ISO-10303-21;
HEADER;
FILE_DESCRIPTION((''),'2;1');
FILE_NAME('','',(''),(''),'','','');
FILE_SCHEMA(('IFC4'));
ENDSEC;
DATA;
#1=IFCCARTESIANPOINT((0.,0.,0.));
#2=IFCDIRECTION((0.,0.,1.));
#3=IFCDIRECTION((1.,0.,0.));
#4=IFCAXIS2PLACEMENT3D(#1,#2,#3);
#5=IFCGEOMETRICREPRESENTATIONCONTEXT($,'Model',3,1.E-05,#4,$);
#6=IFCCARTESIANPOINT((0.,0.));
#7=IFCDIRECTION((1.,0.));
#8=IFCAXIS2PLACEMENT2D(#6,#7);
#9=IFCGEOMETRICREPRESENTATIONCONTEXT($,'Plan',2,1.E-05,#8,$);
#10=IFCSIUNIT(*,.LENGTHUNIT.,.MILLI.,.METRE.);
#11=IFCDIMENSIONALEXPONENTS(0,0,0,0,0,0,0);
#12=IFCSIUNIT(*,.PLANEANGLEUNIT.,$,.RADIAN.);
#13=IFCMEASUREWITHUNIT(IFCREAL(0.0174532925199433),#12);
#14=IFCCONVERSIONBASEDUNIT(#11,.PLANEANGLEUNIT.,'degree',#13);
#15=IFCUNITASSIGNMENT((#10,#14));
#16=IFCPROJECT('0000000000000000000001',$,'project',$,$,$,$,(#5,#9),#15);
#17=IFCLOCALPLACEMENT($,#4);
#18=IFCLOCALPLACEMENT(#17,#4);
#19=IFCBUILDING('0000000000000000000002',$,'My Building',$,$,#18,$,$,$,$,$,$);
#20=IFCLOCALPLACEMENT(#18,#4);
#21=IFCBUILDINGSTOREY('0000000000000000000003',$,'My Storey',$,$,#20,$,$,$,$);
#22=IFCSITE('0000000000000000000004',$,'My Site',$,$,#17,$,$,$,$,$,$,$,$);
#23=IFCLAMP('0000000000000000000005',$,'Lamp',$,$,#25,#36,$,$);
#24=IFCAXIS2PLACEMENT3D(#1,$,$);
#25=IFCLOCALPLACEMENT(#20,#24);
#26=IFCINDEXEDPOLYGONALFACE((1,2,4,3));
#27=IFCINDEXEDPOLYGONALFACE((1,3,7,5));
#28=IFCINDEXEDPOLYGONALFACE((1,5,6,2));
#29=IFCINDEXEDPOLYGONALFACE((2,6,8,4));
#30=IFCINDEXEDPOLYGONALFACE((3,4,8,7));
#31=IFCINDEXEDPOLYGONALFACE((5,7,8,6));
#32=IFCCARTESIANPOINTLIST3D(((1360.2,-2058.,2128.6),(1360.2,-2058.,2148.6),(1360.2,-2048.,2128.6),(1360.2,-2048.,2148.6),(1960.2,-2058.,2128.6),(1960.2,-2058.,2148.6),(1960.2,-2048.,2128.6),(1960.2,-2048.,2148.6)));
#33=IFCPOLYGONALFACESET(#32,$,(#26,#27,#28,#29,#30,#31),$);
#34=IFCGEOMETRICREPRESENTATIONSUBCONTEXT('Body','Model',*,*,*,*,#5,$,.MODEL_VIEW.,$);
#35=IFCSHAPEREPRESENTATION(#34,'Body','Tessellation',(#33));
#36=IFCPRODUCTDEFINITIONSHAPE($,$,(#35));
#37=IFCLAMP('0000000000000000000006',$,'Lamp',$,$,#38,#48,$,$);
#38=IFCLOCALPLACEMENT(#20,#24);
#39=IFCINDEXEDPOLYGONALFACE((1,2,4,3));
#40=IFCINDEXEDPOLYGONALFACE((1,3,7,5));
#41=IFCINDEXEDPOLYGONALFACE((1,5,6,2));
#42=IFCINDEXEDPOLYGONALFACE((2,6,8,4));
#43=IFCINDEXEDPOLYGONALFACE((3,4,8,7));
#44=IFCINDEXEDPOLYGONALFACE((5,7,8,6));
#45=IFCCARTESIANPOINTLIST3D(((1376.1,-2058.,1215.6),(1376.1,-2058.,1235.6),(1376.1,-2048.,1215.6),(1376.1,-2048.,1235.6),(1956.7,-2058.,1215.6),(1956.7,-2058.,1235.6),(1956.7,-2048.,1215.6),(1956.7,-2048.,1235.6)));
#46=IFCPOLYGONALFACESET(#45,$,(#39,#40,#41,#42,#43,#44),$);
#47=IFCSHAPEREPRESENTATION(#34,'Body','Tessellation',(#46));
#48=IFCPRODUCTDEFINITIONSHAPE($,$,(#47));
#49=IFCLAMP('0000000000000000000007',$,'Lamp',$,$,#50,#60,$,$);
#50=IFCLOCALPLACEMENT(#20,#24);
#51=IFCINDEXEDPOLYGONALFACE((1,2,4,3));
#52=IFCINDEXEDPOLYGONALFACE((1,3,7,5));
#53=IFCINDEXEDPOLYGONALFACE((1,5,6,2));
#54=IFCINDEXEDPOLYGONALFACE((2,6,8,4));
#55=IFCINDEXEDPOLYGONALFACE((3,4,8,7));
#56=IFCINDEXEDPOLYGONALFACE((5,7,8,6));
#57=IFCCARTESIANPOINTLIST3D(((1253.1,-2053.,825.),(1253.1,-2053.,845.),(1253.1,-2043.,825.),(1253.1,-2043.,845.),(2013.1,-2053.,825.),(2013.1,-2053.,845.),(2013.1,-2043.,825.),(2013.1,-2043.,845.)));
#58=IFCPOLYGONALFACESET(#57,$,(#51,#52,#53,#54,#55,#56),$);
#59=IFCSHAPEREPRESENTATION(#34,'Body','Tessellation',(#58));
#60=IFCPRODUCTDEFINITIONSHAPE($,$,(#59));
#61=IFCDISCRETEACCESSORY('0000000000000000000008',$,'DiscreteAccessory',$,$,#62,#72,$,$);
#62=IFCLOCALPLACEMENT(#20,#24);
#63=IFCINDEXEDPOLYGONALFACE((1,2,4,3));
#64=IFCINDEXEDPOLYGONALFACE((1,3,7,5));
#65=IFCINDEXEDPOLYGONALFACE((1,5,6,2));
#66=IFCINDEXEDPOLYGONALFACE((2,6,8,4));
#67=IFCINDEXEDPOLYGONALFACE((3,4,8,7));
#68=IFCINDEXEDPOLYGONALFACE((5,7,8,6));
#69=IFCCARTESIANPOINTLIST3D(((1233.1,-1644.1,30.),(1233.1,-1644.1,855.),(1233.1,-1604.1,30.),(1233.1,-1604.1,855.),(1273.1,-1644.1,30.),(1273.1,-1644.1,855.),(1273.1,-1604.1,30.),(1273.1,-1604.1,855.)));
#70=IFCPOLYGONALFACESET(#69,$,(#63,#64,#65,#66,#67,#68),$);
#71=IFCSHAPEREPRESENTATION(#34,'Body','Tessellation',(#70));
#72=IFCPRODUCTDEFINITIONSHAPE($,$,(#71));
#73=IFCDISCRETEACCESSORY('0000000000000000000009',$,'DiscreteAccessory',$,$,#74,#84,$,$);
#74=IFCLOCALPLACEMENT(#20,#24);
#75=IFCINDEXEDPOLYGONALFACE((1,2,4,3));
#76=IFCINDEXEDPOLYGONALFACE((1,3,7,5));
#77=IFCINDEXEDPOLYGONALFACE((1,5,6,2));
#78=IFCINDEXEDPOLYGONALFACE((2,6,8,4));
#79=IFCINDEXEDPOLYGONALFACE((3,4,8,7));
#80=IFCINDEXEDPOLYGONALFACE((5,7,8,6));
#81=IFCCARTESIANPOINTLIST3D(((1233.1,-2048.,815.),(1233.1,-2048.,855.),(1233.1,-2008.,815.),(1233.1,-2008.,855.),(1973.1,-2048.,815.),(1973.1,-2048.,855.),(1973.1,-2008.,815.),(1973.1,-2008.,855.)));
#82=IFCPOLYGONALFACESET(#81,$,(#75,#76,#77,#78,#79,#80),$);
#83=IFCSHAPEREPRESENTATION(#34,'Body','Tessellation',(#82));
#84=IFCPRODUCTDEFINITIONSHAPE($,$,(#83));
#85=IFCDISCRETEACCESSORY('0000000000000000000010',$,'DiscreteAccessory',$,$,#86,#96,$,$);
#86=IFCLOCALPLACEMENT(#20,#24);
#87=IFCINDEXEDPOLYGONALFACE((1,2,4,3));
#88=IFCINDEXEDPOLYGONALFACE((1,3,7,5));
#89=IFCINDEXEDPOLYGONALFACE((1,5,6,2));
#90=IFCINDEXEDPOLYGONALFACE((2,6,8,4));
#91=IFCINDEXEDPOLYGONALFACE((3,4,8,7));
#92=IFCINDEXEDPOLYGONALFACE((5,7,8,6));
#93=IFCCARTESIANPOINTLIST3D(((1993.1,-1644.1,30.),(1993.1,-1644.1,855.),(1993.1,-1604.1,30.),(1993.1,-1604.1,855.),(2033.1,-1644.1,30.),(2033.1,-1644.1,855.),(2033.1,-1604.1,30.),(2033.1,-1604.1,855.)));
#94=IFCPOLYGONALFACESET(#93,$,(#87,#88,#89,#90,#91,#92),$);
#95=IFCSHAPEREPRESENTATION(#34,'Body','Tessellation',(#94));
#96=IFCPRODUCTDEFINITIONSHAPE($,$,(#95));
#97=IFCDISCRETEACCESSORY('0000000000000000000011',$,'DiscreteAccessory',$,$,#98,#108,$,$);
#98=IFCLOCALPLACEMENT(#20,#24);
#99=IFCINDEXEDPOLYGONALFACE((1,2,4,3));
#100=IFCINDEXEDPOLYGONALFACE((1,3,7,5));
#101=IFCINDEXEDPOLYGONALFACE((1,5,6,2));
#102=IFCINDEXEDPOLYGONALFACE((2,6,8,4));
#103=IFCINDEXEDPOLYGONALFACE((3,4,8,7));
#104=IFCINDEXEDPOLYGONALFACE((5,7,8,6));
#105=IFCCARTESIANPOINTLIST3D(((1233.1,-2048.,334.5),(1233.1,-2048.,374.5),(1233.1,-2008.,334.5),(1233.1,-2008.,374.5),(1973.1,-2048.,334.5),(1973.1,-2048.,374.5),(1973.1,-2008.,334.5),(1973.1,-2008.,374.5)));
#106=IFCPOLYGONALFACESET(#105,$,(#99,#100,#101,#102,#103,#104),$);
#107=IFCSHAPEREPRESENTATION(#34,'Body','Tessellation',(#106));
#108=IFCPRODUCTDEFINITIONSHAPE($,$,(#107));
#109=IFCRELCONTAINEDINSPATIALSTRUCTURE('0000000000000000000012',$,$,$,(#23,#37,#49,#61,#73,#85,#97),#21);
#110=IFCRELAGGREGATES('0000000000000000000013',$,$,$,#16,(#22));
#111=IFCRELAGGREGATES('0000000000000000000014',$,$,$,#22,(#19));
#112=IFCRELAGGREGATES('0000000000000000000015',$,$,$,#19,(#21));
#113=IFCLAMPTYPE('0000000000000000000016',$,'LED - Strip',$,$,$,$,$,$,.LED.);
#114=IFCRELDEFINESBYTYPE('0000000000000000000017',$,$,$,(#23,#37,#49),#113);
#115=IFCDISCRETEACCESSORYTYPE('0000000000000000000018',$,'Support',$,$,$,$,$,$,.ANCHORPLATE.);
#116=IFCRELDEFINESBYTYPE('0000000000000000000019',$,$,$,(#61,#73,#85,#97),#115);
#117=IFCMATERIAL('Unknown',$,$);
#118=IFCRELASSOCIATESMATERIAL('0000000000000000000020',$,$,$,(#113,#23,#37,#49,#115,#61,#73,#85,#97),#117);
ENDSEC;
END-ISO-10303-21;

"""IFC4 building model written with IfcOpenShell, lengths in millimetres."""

from ifc_helpers import new_model, entity, si_unit, converted_unit, frame, origin_with_axes, origin_2d_with_axis, place, context, subcontext, project, spatial, line, indexed_curve, outline, extrude, material, material_profile, profile_set, profile_usage, type_object, element, save


model = new_model("IFC4")

# Units and contexts
model_context = context("Model", 3, precision=1e-05, world=origin_with_axes())
plan_context = context("Plan", 2, precision=1e-05, world=origin_2d_with_axis())
body_context = subcontext(model_context, "Body", "Model", "MODEL_VIEW")
ifc_project = project(units=[si_unit("LENGTHUNIT", "METRE", prefix="MILLI"), converted_unit("PLANEANGLEUNIT", "degree", entity("IfcReal", 0.0174532925199433), si_unit("PLANEANGLEUNIT", "RADIAN"), dimensions=[0, 0, 0, 0, 0, 0, 0])], contexts=[model_context, plan_context])

# Site, building, storey
site_placement = place(None, origin_with_axes())
site = spatial("IfcSite", under=ifc_project, at=site_placement, Name="My Site")
building_placement = place(site_placement, origin_with_axes())
building = spatial("IfcBuilding", under=site, at=building_placement, Name="My Building")
storey_placement = place(building_placement, origin_with_axes())
storey = spatial("IfcBuildingStorey", under=building, at=storey_placement, Name="My Storey")

# Shared definitions
ifc_material_1 = material(Name="Unknown")

# Lamps
ifc_material_profile_1 = material_profile(ifc_material_1, outline(indexed_curve([(-10.0, 10.0), (-10.0, 0.0), (10.0, 0.0), (10.0, 10.0)], segments=[line(4, 1), line(1, 2), line(2, 3), line(3, 4)], self_intersect=False)))
ifc_profile_set_1 = profile_set([ifc_material_profile_1])
lamp_type = type_object("IfcLampType", Name="LED - Strip", PredefinedType="LED", material=ifc_profile_set_1)
ifc_profile_usage_1 = profile_usage(ifc_profile_set_1, cardinal=5)
lamp_1_placement = place(storey_placement, frame((1960.2, -2058.0, 2138.6), z_axis=(-1.0, 0.0, 0.0), x_axis=(0.0, 0.0, 1.0)))
element("IfcLamp", 1, at=lamp_1_placement, inside=storey, type_object=lamp_type, material=ifc_profile_usage_1, Name="Lamp", context=body_context, shape_type="SweptSolid", body=[
    extrude(outline(indexed_curve([(-10.0, 10.0), (-10.0, 0.0), (10.0, 0.0), (10.0, 10.0)], segments=[line(4, 1), line(1, 2), line(2, 3), line(3, 4)], self_intersect=False)), origin_with_axes(), (0.0, 0.0, 1.0), 600.0),
])
ifc_profile_usage_2 = profile_usage(ifc_profile_set_1, cardinal=5)
lamp_2_placement = place(storey_placement, frame((1956.7, -2058.0, 1225.6), z_axis=(-1.0, 0.0, 0.0), x_axis=(0.0, 0.0, 1.0)))
element("IfcLamp", 2, at=lamp_2_placement, inside=storey, type_object=lamp_type, material=ifc_profile_usage_2, Name="Lamp", context=body_context, shape_type="SweptSolid", body=[
    extrude(outline(indexed_curve([(-10.0, 10.0), (-10.0, 0.0), (10.0, 0.0), (10.0, 10.0)], segments=[line(4, 1), line(1, 2), line(2, 3), line(3, 4)], self_intersect=False)), origin_with_axes(), (0.0, 0.0, 1.0), 580.6),
])
ifc_profile_usage_3 = profile_usage(ifc_profile_set_1, cardinal=5)
lamp_3_placement = place(storey_placement, frame((2013.1, -2053.0, 835.0), z_axis=(-1.0, 0.0, 0.0), x_axis=(0.0, 0.0, 1.0)))
element("IfcLamp", 3, at=lamp_3_placement, inside=storey, type_object=lamp_type, material=ifc_profile_usage_3, Name="Lamp", context=body_context, shape_type="SweptSolid", body=[
    extrude(outline(indexed_curve([(-10.0, 10.0), (-10.0, 0.0), (10.0, 0.0), (10.0, 10.0)], segments=[line(4, 1), line(1, 2), line(2, 3), line(3, 4)], self_intersect=False)), origin_with_axes(), (0.0, 0.0, 1.0), 760.0),
])

# Discrete accessories
ifc_material_profile_2 = material_profile(ifc_material_1, outline(indexed_curve([(-20.0, -20.0), (20.0, -20.0), (20.0, 20.0), (-20.0, 20.0), (-20.0, -20.0)])))
ifc_profile_set_2 = profile_set([ifc_material_profile_2])
ifc_profile_usage_4 = profile_usage(ifc_profile_set_2, cardinal=5)
discrete_accessory_type = type_object("IfcDiscreteAccessoryType", Name="Support", PredefinedType="ANCHORPLATE", material=ifc_profile_set_2)
discrete_accessory_1_placement = place(storey_placement, frame((1253.1, -1624.1, 30.0), z_axis=(0.0, 0.0, 1.0), x_axis=(1.0, 0.0, 0.0)))
element("IfcDiscreteAccessory", 4, at=discrete_accessory_1_placement, inside=storey, type_object=discrete_accessory_type, material=ifc_profile_usage_4, Name="DiscreteAccessory", context=body_context, shape_type="SweptSolid", body=[
    extrude(outline(indexed_curve([(-20.0, -20.0), (20.0, -20.0), (20.0, 20.0), (-20.0, 20.0), (-20.0, -20.0)])), origin_with_axes(), (0.0, 0.0, 1.0), 825.0),
])
ifc_profile_usage_5 = profile_usage(ifc_profile_set_2, cardinal=5)
discrete_accessory_2_placement = place(storey_placement, frame((1233.1, -2028.0, 835.0), z_axis=(1.0, 0.0, 0.0), x_axis=(0.0, -1.0, 0.0)))
element("IfcDiscreteAccessory", 5, at=discrete_accessory_2_placement, inside=storey, type_object=discrete_accessory_type, material=ifc_profile_usage_5, Name="DiscreteAccessory", context=body_context, shape_type="SweptSolid", body=[
    extrude(outline(indexed_curve([(-20.0, -20.0), (20.0, -20.0), (20.0, 20.0), (-20.0, 20.0), (-20.0, -20.0)])), origin_with_axes(), (0.0, 0.0, 1.0), 740.0),
])
ifc_profile_usage_6 = profile_usage(ifc_profile_set_2, cardinal=5)
discrete_accessory_3_placement = place(storey_placement, frame((2013.1, -1624.1, 30.0), z_axis=(0.0, 0.0, 1.0), x_axis=(1.0, 0.0, 0.0)))
element("IfcDiscreteAccessory", 6, at=discrete_accessory_3_placement, inside=storey, type_object=discrete_accessory_type, material=ifc_profile_usage_6, Name="DiscreteAccessory", context=body_context, shape_type="SweptSolid", body=[
    extrude(outline(indexed_curve([(-20.0, -20.0), (20.0, -20.0), (20.0, 20.0), (-20.0, 20.0), (-20.0, -20.0)])), origin_with_axes(), (0.0, 0.0, 1.0), 825.0),
])
ifc_profile_usage_7 = profile_usage(ifc_profile_set_2, cardinal=5)
discrete_accessory_4_placement = place(storey_placement, frame((1233.1, -2028.0, 354.5), z_axis=(1.0, 0.0, 0.0), x_axis=(0.0, -1.0, 0.0)))
element("IfcDiscreteAccessory", 7, at=discrete_accessory_4_placement, inside=storey, type_object=discrete_accessory_type, material=ifc_profile_usage_7, Name="DiscreteAccessory", context=body_context, shape_type="SweptSolid", body=[
    extrude(outline(indexed_curve([(-20.0, -20.0), (20.0, -20.0), (20.0, 20.0), (-20.0, 20.0), (-20.0, -20.0)])), origin_with_axes(), (0.0, 0.0, 1.0), 740.0),
])

save(model, "model.ifc")
